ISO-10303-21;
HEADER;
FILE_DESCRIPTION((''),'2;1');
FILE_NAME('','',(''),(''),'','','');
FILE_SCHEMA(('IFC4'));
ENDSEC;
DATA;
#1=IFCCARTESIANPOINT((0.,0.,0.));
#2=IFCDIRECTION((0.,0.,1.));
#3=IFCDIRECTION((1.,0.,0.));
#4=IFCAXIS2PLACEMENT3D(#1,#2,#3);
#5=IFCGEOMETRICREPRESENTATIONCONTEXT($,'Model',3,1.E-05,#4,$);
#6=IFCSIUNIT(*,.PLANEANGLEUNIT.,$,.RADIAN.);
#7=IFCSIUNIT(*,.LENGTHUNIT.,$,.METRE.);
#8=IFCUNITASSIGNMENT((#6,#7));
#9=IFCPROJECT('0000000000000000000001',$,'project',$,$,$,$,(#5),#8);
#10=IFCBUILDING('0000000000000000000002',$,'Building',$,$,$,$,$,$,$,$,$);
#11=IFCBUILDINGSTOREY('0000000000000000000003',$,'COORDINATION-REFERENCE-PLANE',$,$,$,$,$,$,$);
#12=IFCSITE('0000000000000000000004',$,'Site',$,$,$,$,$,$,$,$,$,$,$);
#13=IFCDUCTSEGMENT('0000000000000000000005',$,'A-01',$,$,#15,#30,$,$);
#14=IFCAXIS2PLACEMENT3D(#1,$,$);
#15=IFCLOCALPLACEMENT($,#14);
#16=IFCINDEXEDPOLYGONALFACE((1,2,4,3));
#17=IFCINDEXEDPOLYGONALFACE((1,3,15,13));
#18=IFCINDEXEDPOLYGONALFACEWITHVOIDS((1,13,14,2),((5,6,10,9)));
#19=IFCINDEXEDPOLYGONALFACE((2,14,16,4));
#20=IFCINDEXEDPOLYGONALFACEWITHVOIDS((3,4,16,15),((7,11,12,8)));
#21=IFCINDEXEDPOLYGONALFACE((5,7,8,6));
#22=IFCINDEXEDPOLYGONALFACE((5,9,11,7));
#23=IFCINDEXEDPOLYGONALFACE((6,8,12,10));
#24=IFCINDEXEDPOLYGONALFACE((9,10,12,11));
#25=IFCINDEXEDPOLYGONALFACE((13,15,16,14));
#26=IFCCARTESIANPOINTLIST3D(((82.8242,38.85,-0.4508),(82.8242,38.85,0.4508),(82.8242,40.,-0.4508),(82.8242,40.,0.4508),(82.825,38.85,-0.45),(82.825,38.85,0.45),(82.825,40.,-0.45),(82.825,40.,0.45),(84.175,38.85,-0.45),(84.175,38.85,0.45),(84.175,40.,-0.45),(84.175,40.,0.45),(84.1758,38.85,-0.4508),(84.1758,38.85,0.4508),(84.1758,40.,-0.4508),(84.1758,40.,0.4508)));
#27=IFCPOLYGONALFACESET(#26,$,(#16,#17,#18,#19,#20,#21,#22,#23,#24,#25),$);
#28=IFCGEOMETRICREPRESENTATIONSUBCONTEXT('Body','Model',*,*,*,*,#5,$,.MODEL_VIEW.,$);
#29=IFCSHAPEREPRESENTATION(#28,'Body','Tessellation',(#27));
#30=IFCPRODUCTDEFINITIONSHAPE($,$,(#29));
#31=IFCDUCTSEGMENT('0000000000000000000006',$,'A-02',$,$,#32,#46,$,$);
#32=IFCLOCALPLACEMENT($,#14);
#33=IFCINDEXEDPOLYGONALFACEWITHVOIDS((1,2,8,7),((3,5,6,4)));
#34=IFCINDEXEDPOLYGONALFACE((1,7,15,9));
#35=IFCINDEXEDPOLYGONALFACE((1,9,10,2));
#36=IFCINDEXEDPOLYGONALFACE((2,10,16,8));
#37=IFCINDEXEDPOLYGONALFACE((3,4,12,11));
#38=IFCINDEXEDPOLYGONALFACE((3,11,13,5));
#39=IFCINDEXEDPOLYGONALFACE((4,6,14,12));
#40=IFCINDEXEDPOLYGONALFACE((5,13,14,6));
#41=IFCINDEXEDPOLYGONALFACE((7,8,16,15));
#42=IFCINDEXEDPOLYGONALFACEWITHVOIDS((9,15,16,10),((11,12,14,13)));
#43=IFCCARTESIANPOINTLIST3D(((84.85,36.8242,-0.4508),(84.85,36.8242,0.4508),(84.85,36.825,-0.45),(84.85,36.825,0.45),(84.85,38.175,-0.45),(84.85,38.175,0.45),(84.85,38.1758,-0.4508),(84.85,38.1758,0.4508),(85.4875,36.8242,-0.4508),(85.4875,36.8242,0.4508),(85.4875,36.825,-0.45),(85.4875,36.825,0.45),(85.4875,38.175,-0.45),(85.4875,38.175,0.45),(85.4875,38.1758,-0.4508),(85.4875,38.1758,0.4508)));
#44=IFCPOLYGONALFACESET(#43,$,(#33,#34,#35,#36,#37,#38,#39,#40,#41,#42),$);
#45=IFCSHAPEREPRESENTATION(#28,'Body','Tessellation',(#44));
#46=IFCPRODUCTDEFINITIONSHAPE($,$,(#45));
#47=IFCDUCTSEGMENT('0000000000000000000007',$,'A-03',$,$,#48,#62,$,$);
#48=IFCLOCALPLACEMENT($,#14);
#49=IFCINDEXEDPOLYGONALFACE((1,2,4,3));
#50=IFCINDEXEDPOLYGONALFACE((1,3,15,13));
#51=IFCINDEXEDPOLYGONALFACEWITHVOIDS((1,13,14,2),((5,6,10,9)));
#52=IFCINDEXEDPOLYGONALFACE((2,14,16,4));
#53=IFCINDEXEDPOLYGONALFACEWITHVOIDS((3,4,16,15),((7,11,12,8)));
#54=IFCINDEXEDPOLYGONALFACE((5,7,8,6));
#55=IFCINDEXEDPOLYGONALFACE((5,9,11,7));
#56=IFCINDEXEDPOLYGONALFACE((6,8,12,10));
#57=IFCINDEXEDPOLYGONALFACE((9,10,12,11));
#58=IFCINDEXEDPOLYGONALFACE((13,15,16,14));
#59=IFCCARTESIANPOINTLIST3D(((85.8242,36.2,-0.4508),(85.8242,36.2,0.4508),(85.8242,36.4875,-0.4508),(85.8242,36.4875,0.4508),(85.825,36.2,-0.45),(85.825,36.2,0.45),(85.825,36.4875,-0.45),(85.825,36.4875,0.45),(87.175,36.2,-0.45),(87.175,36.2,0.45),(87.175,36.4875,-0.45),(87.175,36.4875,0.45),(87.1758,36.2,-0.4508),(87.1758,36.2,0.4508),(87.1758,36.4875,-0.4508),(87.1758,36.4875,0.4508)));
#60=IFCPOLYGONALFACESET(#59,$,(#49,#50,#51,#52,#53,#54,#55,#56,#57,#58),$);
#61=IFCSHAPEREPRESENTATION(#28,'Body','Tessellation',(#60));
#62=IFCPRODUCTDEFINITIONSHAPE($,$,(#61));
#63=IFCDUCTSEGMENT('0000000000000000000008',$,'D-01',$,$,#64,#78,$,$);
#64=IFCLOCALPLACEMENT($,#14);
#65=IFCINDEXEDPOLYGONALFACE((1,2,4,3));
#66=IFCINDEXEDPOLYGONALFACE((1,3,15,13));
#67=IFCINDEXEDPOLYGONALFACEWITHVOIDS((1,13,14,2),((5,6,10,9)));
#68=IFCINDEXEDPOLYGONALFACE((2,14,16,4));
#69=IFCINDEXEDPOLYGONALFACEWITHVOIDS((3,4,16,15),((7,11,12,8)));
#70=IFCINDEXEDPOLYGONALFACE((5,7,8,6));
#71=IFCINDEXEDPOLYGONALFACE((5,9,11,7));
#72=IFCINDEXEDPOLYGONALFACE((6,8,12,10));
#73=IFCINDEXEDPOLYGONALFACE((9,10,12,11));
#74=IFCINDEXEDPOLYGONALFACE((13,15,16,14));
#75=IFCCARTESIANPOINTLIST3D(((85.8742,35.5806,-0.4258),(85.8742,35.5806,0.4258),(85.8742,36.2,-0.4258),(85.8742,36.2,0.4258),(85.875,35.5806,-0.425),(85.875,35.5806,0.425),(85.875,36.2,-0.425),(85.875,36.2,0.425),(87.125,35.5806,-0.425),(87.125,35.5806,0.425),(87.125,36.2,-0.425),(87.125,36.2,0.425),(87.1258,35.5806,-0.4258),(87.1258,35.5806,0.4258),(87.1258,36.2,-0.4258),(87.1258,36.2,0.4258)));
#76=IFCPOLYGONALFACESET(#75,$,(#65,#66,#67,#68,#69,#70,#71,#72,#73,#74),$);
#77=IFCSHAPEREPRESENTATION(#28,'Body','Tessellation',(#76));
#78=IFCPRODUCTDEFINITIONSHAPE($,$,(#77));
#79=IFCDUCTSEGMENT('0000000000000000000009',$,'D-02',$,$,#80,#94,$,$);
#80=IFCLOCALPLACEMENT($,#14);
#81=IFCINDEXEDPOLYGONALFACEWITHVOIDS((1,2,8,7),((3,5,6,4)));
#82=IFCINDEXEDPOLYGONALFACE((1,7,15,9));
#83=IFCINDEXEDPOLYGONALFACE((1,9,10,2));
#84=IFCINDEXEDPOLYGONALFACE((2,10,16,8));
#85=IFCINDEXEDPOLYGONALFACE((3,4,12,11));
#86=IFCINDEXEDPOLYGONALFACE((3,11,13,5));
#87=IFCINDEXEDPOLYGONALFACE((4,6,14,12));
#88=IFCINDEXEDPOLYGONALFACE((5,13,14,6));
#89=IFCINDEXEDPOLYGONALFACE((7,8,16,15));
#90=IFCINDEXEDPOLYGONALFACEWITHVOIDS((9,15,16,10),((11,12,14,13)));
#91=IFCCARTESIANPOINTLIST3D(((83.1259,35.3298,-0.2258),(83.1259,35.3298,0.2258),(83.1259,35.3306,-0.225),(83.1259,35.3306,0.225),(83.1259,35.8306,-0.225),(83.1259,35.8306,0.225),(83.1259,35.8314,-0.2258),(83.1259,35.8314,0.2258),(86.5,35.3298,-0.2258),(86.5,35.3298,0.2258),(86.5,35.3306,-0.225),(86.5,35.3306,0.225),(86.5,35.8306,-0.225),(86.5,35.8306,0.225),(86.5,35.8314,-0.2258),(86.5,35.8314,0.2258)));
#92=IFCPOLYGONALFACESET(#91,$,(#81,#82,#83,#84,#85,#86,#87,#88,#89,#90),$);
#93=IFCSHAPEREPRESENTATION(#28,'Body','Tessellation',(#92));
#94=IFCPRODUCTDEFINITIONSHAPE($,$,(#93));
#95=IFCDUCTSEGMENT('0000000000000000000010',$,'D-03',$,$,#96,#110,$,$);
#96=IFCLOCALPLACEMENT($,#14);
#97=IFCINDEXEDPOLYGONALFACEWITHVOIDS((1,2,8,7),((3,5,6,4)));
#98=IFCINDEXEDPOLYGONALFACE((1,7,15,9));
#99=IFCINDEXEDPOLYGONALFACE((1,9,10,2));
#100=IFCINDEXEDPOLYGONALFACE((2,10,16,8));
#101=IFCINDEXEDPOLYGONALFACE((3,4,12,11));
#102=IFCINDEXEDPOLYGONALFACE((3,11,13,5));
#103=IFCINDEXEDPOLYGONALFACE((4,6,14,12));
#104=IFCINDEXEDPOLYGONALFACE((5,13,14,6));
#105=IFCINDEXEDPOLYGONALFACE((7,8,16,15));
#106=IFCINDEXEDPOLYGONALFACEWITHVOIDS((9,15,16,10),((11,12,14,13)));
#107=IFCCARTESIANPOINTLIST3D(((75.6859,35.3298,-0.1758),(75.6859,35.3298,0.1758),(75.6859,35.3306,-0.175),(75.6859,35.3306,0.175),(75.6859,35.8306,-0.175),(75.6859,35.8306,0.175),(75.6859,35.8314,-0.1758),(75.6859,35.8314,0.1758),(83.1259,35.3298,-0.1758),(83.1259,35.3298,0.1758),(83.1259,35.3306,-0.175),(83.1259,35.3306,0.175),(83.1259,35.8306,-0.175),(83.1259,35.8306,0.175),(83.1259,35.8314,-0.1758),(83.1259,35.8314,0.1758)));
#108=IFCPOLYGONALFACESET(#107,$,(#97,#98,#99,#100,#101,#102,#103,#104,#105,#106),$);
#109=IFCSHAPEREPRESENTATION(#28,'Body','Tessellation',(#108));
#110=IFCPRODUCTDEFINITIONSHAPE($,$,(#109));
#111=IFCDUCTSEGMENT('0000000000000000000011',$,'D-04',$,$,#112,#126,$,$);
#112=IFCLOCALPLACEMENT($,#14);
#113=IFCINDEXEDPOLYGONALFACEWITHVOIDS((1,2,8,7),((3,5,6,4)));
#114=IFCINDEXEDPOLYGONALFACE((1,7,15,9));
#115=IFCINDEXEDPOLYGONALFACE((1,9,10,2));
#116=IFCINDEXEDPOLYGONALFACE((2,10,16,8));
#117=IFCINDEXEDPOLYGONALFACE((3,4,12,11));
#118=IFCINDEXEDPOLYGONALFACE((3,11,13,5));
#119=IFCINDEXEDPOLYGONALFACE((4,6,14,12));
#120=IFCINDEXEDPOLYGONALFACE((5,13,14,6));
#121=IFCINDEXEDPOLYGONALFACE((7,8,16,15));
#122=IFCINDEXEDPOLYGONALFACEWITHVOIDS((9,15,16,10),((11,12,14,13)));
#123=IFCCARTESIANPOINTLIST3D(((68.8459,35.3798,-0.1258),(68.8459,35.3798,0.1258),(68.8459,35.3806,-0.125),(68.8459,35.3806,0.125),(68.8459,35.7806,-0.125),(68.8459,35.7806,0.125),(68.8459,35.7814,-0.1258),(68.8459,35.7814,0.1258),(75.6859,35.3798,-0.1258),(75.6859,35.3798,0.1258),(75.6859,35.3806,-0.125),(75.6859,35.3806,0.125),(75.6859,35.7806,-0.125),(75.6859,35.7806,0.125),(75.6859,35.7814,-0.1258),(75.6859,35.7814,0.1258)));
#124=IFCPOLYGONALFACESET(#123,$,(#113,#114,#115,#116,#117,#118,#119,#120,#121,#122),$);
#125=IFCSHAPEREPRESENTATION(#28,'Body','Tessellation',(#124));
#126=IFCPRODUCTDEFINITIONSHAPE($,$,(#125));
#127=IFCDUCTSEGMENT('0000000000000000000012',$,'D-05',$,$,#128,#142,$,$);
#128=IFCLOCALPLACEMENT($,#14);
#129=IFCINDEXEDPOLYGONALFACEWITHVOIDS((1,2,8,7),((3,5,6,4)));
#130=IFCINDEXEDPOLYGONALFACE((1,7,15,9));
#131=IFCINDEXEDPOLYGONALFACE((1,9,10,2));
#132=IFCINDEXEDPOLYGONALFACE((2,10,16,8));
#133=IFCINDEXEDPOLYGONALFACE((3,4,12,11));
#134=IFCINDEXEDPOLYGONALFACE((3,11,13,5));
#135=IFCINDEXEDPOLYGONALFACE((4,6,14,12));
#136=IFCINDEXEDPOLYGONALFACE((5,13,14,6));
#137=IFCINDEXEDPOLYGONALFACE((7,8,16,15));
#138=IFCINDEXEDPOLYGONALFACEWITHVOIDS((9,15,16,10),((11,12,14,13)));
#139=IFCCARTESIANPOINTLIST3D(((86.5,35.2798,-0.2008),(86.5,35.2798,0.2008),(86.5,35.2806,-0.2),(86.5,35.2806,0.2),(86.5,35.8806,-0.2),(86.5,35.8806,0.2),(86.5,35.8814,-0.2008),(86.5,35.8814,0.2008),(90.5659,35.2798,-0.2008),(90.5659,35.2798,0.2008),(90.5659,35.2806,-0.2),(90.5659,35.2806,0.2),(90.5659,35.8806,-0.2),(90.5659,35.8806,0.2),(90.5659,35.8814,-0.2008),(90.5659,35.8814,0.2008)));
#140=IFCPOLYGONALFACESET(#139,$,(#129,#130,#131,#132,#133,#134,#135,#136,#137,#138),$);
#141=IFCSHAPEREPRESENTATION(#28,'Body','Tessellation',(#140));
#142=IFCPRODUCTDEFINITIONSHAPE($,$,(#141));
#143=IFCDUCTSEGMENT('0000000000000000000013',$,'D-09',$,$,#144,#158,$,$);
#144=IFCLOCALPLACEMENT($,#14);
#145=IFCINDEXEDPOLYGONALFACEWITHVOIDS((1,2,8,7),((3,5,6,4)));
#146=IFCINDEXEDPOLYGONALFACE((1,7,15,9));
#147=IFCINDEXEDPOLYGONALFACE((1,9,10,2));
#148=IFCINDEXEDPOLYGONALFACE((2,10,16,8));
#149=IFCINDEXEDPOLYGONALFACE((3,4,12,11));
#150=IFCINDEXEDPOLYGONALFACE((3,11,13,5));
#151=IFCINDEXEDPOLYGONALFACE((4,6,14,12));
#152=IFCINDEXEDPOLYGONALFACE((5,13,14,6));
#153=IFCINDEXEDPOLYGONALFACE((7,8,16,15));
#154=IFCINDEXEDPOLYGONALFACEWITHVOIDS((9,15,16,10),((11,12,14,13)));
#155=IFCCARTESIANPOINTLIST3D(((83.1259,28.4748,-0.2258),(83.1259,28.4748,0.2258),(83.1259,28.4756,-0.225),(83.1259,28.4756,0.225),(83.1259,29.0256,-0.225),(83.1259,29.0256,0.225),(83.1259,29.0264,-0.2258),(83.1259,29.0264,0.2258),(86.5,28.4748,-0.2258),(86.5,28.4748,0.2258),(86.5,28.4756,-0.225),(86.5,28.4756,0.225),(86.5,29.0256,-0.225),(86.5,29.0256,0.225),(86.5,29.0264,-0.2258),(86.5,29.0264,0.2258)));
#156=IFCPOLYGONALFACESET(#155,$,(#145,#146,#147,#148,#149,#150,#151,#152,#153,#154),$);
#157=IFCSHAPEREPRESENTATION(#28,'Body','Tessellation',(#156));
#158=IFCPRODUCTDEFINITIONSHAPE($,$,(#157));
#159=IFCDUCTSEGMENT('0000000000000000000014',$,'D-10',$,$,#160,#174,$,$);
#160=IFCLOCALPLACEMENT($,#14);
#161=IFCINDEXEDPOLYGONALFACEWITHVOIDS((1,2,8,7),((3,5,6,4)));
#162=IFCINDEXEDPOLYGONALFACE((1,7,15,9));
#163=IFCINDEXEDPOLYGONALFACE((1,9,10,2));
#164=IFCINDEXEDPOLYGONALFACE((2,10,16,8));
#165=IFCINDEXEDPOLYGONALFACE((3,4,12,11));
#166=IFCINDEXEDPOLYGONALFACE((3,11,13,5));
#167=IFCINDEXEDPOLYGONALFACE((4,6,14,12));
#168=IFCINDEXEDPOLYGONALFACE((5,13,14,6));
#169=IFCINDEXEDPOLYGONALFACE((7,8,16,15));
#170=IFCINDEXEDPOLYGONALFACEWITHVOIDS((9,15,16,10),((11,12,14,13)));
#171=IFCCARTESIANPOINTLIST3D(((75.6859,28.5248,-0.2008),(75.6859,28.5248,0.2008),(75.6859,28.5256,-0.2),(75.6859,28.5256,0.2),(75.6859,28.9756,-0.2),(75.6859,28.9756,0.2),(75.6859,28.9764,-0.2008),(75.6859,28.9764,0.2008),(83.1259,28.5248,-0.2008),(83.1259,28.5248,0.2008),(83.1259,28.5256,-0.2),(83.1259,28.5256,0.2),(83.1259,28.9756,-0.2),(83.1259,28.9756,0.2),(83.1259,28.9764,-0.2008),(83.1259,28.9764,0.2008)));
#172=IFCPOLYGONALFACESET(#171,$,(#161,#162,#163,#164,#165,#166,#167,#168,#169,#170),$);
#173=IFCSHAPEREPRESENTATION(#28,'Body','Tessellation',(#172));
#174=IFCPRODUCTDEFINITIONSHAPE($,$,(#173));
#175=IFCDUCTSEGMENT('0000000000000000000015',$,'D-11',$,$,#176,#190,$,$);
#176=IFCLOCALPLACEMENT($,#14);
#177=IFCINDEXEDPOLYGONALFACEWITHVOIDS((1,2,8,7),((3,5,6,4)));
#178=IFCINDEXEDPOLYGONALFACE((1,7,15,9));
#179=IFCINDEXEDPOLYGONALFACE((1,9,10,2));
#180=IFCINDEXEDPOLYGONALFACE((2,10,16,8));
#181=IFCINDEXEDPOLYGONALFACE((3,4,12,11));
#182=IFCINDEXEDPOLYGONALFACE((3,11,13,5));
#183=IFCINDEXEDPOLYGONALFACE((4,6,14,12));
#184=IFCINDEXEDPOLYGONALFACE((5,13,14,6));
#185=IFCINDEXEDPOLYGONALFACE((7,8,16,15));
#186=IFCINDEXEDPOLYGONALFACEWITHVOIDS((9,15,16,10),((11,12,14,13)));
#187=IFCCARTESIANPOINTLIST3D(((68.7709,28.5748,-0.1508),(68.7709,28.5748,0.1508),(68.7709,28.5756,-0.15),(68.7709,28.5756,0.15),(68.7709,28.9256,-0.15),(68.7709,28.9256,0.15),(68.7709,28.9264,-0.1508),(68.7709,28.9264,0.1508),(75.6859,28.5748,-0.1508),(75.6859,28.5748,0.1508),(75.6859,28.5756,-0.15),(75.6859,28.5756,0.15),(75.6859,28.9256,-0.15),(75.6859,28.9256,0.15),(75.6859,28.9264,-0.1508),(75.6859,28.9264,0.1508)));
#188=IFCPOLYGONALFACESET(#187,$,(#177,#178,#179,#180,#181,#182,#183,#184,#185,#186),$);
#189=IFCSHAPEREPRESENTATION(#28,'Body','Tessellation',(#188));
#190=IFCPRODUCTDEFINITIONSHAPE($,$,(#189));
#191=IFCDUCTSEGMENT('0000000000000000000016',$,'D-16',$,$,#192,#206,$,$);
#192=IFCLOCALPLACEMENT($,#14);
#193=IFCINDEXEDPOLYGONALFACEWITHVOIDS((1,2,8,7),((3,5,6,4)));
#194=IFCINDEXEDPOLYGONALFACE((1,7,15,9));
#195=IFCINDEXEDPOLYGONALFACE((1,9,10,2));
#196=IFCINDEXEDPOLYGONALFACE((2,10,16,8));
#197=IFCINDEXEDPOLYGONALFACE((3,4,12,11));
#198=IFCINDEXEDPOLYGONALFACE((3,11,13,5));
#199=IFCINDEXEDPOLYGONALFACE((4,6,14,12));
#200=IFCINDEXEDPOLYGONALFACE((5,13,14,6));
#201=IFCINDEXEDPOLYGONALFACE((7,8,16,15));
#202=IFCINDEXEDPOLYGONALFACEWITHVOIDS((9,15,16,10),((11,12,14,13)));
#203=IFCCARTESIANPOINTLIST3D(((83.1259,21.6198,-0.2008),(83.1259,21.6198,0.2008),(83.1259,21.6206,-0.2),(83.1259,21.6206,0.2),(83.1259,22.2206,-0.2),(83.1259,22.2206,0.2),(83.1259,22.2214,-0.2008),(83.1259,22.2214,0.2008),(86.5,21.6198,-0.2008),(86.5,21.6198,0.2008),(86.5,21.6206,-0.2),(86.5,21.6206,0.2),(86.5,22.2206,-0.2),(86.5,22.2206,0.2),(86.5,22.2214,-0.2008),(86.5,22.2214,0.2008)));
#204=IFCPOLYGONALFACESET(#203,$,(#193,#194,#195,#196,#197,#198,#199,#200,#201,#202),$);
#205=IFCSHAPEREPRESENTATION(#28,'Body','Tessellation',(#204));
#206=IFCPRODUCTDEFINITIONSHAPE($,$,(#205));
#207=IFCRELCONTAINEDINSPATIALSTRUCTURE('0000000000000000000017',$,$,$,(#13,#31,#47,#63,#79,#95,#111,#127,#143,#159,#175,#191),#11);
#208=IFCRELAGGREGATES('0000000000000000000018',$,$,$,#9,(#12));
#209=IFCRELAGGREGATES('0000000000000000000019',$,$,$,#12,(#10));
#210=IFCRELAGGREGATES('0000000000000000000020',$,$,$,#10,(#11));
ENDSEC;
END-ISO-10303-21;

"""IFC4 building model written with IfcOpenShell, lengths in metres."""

from ifc_helpers import new_model, si_unit, frame, origin, origin_with_axes, place, context, subcontext, project, spatial, hollow_rectangle, extrude, element, save


model = new_model("IFC4")

# Units and contexts
model_context = context("Model", 3, precision=1e-05, world=origin_with_axes())
body_context = subcontext(model_context, "Body", "Model", "MODEL_VIEW")
ifc_project = project(units=[si_unit("PLANEANGLEUNIT", "RADIAN"), si_unit("LENGTHUNIT", "METRE")], contexts=[model_context])

# Site, building, storey
site = spatial("IfcSite", under=ifc_project, Name="Site")
building = spatial("IfcBuilding", under=site, Name="Building")
storey = spatial("IfcBuildingStorey", under=building, Name="COORDINATION-REFERENCE-PLANE")

# Duct segments
duct_segment_1_placement = place(None, frame((83.5, 38.85, 0.0), z_axis=(0.0, 1.0, 0.0), x_axis=(1.0, 0.0, 0.0)))
element("IfcDuctSegment", 1, at=duct_segment_1_placement, inside=storey, Name="A-01", context=body_context, shape_type="SweptSolid", body=[
    extrude(hollow_rectangle(XDim=1.3516, YDim=0.9016, WallThickness=0.0008), origin(), (0.0, 0.0, 1.0), 1.15),
])
duct_segment_2_placement = place(None, frame((84.85, 37.5, 0.0), z_axis=(1.0, 0.0, 0.0), x_axis=(0.0, 1.0, 0.0)))
element("IfcDuctSegment", 2, at=duct_segment_2_placement, inside=storey, Name="A-02", context=body_context, shape_type="SweptSolid", body=[
    extrude(hollow_rectangle(XDim=1.3516, YDim=0.9016, WallThickness=0.0008), origin(), (0.0, 0.0, 1.0), 0.6375),
])
duct_segment_3_placement = place(None, frame((86.5, 36.2, 0.0), z_axis=(0.0, 1.0, 0.0), x_axis=(1.0, 0.0, 0.0)))
element("IfcDuctSegment", 3, at=duct_segment_3_placement, inside=storey, Name="A-03", context=body_context, shape_type="SweptSolid", body=[
    extrude(hollow_rectangle(XDim=1.3516, YDim=0.9016, WallThickness=0.0008), origin(), (0.0, 0.0, 1.0), 0.2875),
])
duct_segment_4_placement = place(None, frame((86.5, 35.5806, 0.0), z_axis=(0.0, 1.0, 0.0), x_axis=(1.0, 0.0, 0.0)))
element("IfcDuctSegment", 4, at=duct_segment_4_placement, inside=storey, Name="D-01", context=body_context, shape_type="SweptSolid", body=[
    extrude(hollow_rectangle(XDim=1.2516, YDim=0.8516, WallThickness=0.0008), origin(), (0.0, 0.0, 1.0), 0.6194),
])
duct_segment_5_placement = place(None, frame((83.1259, 35.5806, 0.0), z_axis=(1.0, 0.0, 0.0), x_axis=(0.0, 1.0, 0.0)))
element("IfcDuctSegment", 5, at=duct_segment_5_placement, inside=storey, Name="D-02", context=body_context, shape_type="SweptSolid", body=[
    extrude(hollow_rectangle(XDim=0.5016, YDim=0.4516, WallThickness=0.0008), origin(), (0.0, 0.0, 1.0), 3.3741),
])
duct_segment_6_placement = place(None, frame((75.6859, 35.5806, 0.0), z_axis=(1.0, 0.0, 0.0), x_axis=(0.0, 1.0, 0.0)))
element("IfcDuctSegment", 6, at=duct_segment_6_placement, inside=storey, Name="D-03", context=body_context, shape_type="SweptSolid", body=[
    extrude(hollow_rectangle(XDim=0.5016, YDim=0.3516, WallThickness=0.0008), origin(), (0.0, 0.0, 1.0), 7.44),
])
duct_segment_7_placement = place(None, frame((68.8459, 35.5806, 0.0), z_axis=(1.0, 0.0, 0.0), x_axis=(0.0, 1.0, 0.0)))
element("IfcDuctSegment", 7, at=duct_segment_7_placement, inside=storey, Name="D-04", context=body_context, shape_type="SweptSolid", body=[
    extrude(hollow_rectangle(XDim=0.4016, YDim=0.2516, WallThickness=0.0008), origin(), (0.0, 0.0, 1.0), 6.84),
])
duct_segment_8_placement = place(None, frame((86.5, 35.5806, 0.0), z_axis=(1.0, 0.0, 0.0), x_axis=(0.0, 1.0, 0.0)))
element("IfcDuctSegment", 8, at=duct_segment_8_placement, inside=storey, Name="D-05", context=body_context, shape_type="SweptSolid", body=[
    extrude(hollow_rectangle(XDim=0.6016, YDim=0.4016, WallThickness=0.0008), origin(), (0.0, 0.0, 1.0), 4.0659),
])
duct_segment_9_placement = place(None, frame((83.1259, 28.7506, 0.0), z_axis=(1.0, 0.0, 0.0), x_axis=(0.0, 1.0, 0.0)))
element("IfcDuctSegment", 9, at=duct_segment_9_placement, inside=storey, Name="D-09", context=body_context, shape_type="SweptSolid", body=[
    extrude(hollow_rectangle(XDim=0.5516, YDim=0.4516, WallThickness=0.0008), origin(), (0.0, 0.0, 1.0), 3.3741),
])
duct_segment_10_placement = place(None, frame((75.6859, 28.7506, 0.0), z_axis=(1.0, 0.0, 0.0), x_axis=(0.0, 1.0, 0.0)))
element("IfcDuctSegment", 10, at=duct_segment_10_placement, inside=storey, Name="D-10", context=body_context, shape_type="SweptSolid", body=[
    extrude(hollow_rectangle(XDim=0.4516, YDim=0.4016, WallThickness=0.0008), origin(), (0.0, 0.0, 1.0), 7.44),
])
duct_segment_11_placement = place(None, frame((68.7709, 28.7506, 0.0), z_axis=(1.0, 0.0, 0.0), x_axis=(0.0, 1.0, 0.0)))
element("IfcDuctSegment", 11, at=duct_segment_11_placement, inside=storey, Name="D-11", context=body_context, shape_type="SweptSolid", body=[
    extrude(hollow_rectangle(XDim=0.3516, YDim=0.3016, WallThickness=0.0008), origin(), (0.0, 0.0, 1.0), 6.915),
])
duct_segment_12_placement = place(None, frame((83.1259, 21.9206, 0.0), z_axis=(1.0, 0.0, 0.0), x_axis=(0.0, 1.0, 0.0)))
element("IfcDuctSegment", 12, at=duct_segment_12_placement, inside=storey, Name="D-16", context=body_context, shape_type="SweptSolid", body=[
    extrude(hollow_rectangle(XDim=0.6016, YDim=0.4016, WallThickness=0.0008), origin(), (0.0, 0.0, 1.0), 3.3741),
])

save(model, "model.ifc")
